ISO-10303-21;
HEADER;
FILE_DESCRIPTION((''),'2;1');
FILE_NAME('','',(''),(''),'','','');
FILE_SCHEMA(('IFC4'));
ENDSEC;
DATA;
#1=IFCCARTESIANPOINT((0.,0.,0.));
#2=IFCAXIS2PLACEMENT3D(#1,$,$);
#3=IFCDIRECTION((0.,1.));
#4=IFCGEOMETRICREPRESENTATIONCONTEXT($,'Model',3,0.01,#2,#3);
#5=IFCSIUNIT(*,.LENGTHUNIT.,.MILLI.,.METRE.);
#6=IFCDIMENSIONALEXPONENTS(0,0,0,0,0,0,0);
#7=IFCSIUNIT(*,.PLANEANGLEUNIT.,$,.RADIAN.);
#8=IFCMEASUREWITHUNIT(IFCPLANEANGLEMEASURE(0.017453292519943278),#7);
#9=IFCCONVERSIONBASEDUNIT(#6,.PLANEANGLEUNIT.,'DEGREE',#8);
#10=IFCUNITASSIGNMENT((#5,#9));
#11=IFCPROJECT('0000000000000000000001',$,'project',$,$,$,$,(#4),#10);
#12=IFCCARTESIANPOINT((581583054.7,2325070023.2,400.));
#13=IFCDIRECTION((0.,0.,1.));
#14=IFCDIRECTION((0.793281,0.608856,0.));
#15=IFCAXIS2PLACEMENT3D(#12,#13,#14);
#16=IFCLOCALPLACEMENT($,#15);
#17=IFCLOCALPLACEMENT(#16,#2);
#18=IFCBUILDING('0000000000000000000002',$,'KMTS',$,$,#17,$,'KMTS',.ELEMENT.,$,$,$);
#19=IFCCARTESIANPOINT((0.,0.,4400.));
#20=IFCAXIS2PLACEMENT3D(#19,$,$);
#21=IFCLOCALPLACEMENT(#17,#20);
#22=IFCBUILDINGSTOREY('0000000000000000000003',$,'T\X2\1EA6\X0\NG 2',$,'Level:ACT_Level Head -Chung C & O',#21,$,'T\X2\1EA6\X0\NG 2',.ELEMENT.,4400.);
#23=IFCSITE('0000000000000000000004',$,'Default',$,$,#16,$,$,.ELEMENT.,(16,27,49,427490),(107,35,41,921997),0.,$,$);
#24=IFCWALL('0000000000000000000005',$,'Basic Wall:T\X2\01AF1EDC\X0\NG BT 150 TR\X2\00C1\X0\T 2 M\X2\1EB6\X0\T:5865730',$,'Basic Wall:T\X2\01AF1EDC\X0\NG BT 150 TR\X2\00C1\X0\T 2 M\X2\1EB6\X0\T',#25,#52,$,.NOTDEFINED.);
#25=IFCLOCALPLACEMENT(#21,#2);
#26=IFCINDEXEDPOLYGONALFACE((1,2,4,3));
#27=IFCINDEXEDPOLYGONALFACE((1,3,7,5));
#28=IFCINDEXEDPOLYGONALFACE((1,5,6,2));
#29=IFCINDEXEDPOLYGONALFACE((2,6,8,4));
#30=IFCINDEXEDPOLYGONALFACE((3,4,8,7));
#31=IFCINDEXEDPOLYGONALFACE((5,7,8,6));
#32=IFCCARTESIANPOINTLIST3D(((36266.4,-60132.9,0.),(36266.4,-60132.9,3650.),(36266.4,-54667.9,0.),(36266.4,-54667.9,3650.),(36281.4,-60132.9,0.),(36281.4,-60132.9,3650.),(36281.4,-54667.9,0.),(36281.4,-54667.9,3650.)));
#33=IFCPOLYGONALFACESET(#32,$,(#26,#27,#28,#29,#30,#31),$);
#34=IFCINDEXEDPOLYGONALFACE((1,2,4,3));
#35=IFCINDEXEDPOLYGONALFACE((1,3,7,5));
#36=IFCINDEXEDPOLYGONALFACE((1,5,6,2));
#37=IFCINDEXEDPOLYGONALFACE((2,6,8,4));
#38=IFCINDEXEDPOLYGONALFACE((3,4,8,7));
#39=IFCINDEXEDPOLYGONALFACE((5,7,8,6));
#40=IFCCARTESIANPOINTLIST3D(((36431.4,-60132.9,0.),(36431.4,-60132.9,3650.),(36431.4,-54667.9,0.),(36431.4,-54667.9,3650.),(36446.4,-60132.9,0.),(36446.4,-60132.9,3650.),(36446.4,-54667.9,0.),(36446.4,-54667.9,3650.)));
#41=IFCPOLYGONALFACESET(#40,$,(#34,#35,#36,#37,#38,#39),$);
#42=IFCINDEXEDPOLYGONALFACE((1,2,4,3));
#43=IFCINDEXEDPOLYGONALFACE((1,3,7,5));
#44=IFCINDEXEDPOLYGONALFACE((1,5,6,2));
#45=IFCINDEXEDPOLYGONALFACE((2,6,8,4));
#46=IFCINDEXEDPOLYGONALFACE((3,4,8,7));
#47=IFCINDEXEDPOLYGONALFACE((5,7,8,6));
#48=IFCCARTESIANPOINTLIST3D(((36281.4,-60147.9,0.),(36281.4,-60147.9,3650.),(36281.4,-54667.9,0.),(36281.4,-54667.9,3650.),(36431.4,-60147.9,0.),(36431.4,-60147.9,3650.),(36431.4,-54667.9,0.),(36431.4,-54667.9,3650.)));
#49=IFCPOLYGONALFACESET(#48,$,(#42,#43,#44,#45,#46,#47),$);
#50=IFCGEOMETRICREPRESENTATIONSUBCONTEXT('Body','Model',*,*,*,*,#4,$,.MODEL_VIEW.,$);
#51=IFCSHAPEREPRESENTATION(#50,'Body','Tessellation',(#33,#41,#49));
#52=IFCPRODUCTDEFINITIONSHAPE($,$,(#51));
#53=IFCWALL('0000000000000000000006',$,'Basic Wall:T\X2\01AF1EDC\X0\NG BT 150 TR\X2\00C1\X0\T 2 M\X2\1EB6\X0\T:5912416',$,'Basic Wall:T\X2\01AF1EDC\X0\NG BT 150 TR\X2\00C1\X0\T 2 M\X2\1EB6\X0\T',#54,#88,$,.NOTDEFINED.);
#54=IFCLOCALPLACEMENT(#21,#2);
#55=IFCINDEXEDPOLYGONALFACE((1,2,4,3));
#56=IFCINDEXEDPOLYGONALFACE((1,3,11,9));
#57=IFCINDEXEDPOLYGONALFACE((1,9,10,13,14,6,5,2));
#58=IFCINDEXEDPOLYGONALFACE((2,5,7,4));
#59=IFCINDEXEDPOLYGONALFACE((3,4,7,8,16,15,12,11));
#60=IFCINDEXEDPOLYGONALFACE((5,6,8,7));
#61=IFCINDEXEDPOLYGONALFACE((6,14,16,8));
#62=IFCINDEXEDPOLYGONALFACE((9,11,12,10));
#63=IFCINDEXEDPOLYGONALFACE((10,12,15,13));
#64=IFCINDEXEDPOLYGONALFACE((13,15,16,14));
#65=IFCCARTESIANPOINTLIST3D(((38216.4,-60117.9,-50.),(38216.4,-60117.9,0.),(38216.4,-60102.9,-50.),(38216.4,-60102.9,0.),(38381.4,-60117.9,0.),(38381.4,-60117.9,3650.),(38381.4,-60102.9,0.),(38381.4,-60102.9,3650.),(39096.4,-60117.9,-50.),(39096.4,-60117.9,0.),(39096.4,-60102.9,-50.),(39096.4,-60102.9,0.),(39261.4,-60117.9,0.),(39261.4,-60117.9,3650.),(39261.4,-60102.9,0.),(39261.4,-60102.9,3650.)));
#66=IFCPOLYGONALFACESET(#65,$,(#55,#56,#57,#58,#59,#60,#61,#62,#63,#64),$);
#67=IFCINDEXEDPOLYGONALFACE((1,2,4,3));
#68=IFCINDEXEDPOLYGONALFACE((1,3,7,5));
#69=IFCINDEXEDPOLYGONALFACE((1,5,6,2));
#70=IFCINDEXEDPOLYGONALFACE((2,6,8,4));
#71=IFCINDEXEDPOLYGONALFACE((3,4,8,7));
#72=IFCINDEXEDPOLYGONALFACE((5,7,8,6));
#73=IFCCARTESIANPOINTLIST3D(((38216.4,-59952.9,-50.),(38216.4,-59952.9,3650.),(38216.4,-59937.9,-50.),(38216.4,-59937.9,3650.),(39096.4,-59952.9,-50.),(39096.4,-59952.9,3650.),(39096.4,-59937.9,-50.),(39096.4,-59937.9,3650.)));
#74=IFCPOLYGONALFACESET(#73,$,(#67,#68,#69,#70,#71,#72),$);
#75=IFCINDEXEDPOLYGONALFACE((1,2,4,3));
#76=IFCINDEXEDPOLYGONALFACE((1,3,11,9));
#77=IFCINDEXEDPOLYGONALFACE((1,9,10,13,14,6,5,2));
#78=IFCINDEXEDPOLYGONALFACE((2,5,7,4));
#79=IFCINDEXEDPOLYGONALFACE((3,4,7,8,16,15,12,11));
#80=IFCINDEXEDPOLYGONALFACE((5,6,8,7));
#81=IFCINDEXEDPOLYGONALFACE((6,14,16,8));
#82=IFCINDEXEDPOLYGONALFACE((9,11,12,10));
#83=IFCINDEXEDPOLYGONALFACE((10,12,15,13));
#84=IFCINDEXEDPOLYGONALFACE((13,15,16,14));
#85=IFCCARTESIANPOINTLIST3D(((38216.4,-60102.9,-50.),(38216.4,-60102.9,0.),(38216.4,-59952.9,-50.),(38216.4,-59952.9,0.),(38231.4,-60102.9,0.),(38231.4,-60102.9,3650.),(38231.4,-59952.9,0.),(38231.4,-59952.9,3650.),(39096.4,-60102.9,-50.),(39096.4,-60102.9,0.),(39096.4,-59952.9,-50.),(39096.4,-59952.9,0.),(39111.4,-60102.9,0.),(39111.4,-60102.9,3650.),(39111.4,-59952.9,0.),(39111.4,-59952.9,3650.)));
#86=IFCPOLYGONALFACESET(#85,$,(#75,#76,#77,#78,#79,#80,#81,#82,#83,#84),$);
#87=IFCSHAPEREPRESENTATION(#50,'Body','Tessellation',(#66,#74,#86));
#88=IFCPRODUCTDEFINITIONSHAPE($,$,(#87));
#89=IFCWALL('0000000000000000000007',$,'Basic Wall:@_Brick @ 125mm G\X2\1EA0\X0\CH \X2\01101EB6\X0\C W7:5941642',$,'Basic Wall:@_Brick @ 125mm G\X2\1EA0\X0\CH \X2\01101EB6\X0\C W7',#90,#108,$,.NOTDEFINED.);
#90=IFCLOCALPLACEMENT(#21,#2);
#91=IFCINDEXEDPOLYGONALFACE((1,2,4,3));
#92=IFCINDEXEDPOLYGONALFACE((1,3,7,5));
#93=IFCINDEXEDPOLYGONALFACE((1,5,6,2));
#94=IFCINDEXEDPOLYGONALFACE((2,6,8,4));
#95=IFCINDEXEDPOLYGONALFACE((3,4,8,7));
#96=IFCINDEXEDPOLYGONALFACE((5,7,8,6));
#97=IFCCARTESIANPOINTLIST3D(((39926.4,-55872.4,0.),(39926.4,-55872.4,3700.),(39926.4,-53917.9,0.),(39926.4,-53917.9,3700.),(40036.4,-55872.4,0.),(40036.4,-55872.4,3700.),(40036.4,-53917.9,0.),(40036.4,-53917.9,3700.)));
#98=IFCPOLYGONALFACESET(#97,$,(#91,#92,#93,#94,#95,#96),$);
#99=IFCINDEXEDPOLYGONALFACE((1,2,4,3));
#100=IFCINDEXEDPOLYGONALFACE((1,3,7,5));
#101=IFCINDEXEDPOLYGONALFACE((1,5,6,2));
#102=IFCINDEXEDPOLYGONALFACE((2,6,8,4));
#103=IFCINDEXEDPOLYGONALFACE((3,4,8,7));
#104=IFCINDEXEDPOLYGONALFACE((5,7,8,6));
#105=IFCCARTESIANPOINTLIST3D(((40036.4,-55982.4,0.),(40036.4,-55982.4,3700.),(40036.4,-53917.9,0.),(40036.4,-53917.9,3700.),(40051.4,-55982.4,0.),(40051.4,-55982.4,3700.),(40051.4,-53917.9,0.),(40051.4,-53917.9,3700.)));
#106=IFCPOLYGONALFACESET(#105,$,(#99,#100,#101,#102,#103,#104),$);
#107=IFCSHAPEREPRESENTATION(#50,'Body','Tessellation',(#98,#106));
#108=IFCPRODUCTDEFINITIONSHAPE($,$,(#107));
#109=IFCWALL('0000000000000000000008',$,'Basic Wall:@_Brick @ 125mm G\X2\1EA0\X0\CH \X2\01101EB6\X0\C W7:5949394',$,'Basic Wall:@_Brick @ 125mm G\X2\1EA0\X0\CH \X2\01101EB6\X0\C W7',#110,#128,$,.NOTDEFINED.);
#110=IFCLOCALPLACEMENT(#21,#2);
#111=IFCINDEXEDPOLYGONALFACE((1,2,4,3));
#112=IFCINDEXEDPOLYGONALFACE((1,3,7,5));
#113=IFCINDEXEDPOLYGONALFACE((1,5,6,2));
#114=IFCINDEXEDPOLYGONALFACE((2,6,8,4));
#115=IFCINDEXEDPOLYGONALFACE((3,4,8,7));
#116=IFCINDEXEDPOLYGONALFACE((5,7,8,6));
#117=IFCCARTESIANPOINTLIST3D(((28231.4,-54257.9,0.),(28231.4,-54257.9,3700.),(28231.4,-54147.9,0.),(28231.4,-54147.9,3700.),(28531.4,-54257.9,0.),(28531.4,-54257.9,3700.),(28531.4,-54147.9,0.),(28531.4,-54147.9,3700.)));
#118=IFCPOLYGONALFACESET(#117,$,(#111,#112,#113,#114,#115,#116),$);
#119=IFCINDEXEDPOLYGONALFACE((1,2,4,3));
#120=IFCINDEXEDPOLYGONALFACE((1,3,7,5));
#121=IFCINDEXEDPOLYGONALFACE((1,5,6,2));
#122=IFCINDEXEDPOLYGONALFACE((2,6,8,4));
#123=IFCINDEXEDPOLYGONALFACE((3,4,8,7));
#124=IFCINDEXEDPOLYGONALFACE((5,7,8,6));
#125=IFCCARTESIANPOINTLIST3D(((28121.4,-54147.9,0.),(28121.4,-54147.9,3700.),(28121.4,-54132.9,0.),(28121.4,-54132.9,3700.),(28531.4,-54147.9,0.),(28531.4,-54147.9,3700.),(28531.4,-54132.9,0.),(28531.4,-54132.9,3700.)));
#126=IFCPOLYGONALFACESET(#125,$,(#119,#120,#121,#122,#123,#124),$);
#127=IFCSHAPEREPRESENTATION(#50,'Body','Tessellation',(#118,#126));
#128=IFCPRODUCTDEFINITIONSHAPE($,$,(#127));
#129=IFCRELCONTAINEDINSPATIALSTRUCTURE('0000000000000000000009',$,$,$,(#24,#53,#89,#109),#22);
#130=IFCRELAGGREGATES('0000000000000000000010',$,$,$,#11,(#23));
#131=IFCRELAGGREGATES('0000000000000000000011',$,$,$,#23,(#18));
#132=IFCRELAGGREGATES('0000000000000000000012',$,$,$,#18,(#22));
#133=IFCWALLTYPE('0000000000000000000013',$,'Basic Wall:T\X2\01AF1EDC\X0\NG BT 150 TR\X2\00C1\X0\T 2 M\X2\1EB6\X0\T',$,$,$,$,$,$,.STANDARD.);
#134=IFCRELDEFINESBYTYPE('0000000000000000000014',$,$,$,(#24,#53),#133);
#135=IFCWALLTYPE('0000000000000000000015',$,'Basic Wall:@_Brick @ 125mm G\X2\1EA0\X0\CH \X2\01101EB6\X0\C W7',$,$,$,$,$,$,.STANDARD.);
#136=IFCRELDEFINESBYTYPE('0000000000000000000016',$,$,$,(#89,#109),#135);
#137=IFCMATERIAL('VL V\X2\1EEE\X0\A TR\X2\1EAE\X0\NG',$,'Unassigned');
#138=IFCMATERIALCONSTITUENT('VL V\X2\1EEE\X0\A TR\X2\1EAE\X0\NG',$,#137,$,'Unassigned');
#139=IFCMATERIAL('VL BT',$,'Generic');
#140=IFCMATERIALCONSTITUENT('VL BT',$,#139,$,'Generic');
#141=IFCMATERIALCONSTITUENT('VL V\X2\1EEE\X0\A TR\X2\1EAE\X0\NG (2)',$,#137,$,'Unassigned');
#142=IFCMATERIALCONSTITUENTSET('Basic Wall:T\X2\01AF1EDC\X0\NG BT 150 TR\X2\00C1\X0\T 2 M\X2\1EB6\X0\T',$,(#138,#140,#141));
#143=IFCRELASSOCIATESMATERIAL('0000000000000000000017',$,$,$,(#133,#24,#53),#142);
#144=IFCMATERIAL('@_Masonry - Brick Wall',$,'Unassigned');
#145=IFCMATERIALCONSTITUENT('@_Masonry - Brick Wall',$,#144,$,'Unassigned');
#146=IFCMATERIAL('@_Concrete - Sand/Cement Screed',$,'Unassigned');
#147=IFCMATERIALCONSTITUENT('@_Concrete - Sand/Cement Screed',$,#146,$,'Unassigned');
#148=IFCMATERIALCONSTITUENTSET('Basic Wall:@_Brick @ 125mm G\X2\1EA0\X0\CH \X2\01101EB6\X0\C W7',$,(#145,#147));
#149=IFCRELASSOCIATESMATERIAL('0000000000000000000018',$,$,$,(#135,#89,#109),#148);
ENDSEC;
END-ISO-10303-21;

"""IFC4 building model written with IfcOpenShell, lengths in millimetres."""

from ifc_helpers import new_model, entity, si_unit, converted_unit, direction, frame, origin, place, context, subcontext, project, spatial, indexed_curve, outline, extrude, material, constituent, constituent_set, type_object, element, save


model = new_model("IFC4")

# Units and contexts
model_context = context("Model", 3, precision=0.01, world=origin(), true_north=direction((0.0, 1.0)))
body_context = subcontext(model_context, "Body", "Model", "MODEL_VIEW")
ifc_project = project(units=[si_unit("LENGTHUNIT", "METRE", prefix="MILLI"), converted_unit("PLANEANGLEUNIT", "DEGREE", entity("IfcPlaneAngleMeasure", 0.017453292519943278), si_unit("PLANEANGLEUNIT", "RADIAN"), dimensions=[0, 0, 0, 0, 0, 0, 0])], contexts=[model_context])

# Site, building, storey
site_placement = place(None, frame((581583054.7, 2325070023.2, 400.0), z_axis=(0.0, 0.0, 1.0), x_axis=(0.793281, 0.608856, 0.0)))
site = spatial("IfcSite", under=ifc_project, at=site_placement, Name="Default", CompositionType="ELEMENT", RefLatitude=(16, 27, 49, 427490), RefLongitude=(107, 35, 41, 921997), RefElevation=0.0)
building_placement = place(site_placement, origin())
building = spatial("IfcBuilding", under=site, at=building_placement, Name="KMTS", LongName="KMTS", CompositionType="ELEMENT")
storey_placement = place(building_placement, frame((0.0, 0.0, 4400.0)))
storey = spatial("IfcBuildingStorey", under=building, at=storey_placement, Name="TẦNG 2", ObjectType="Level:ACT_Level Head -Chung C & O", LongName="TẦNG 2", CompositionType="ELEMENT", Elevation=4400.0)

# Wall
ifc_material_1 = material(Name="VL VỮA TRẮNG", Category="Unassigned")
ifc_constituent_1 = constituent(ifc_material_1, Name="VL VỮA TRẮNG", Category="Unassigned")
ifc_material_2 = material(Name="VL BT", Category="Generic")
ifc_constituent_2 = constituent(ifc_material_2, Name="VL BT", Category="Generic")
ifc_constituent_3 = constituent(ifc_material_1, Name="VL VỮA TRẮNG (2)", Category="Unassigned")
ifc_constituent_set_1 = constituent_set(constituents=[ifc_constituent_1, ifc_constituent_2, ifc_constituent_3], Name="Basic Wall:TƯỜNG BT 150 TRÁT 2 MẶT")
wall_type_1 = type_object("IfcWallType", Name="Basic Wall:TƯỜNG BT 150 TRÁT 2 MẶT", PredefinedType="STANDARD", material=ifc_constituent_set_1)
wall_1_placement = place(storey_placement, frame((36356.4, -54667.9, 0.0), z_axis=(0.0, 0.0, 1.0), x_axis=(0.0, -1.0, 0.0)))
element("IfcWall", 1, at=wall_1_placement, inside=storey, type_object=wall_type_1, material=ifc_constituent_set_1, Name="Basic Wall:TƯỜNG BT 150 TRÁT 2 MẶT:5865730", ObjectType="Basic Wall:TƯỜNG BT 150 TRÁT 2 MẶT", PredefinedType="NOTDEFINED", context=body_context, shape_type="SweptSolid", body=[
    extrude(outline(indexed_curve([(-7.5, -2732.5), (7.5, -2732.5), (7.5, 2732.5), (-7.5, 2732.5), (-7.5, -2732.5)], self_intersect=False)), frame((2732.5, -82.5, 0.0), z_axis=(0.0, 0.0, 1.0), x_axis=(0.0, 1.0, 0.0)), (0.0, 0.0, 1.0), 3650.0),
    extrude(outline(indexed_curve([(-7.5, -2732.5), (7.5, -2732.5), (7.5, 2732.5), (-7.5, 2732.5), (-7.5, -2732.5)], self_intersect=False)), frame((2732.5, 82.5, 0.0), z_axis=(0.0, 0.0, 1.0), x_axis=(0.0, -1.0, 0.0)), (0.0, 0.0, 1.0), 3650.0),
    extrude(outline(indexed_curve([(-2740.0, -75.0), (2740.0, -75.0), (2740.0, 75.0), (-2740.0, 75.0), (-2740.0, -75.0)], self_intersect=False)), frame((2740.0, 0.0, 0.0)), (0.0, 0.0, 1.0), 3650.0),
])

# Wall
wall_2_placement = place(storey_placement, frame((38216.4, -60027.9, -50.0)))
element("IfcWall", 2, at=wall_2_placement, inside=storey, type_object=wall_type_1, material=ifc_constituent_set_1, Name="Basic Wall:TƯỜNG BT 150 TRÁT 2 MẶT:5912416", ObjectType="Basic Wall:TƯỜNG BT 150 TRÁT 2 MẶT", PredefinedType="NOTDEFINED", context=body_context, shape_type="SweptSolid", body=[
    extrude(outline(indexed_curve([(-950.0, -522.5), (-900.0, -522.5), (-900.0, -357.5), (2750.0, -357.5), (2750.0, 522.5), (-900.0, 522.5), (-900.0, 357.5), (-950.0, 357.5), (-950.0, -522.5)], self_intersect=False)), frame((522.5, -90.0, 950.0), z_axis=(0.0, 1.0, 0.0), x_axis=(0.0, 0.0, 1.0)), (0.0, 0.0, 1.0), 15.0),
    extrude(outline(indexed_curve([(-7.5, -440.0), (7.5, -440.0), (7.5, 440.0), (-7.5, 440.0), (-7.5, -440.0)], self_intersect=False)), frame((440.0, 82.5, 0.0), z_axis=(0.0, 0.0, 1.0), x_axis=(0.0, -1.0, 0.0)), (0.0, 0.0, 1.0), 3700.0),
    extrude(outline(indexed_curve([(-950.0, -447.5), (-900.0, -447.5), (-900.0, -432.5), (2750.0, -432.5), (2750.0, 447.5), (-900.0, 447.5), (-900.0, 432.5), (-950.0, 432.5), (-950.0, -447.5)], self_intersect=False)), frame((447.5, -75.0, 950.0), z_axis=(0.0, 1.0, 0.0), x_axis=(0.0, 0.0, 1.0)), (0.0, 0.0, 1.0), 150.0),
])

# Walls
ifc_material_3 = material(Name="@_Masonry - Brick Wall", Category="Unassigned")
ifc_constituent_4 = constituent(ifc_material_3, Name="@_Masonry - Brick Wall", Category="Unassigned")
ifc_material_4 = material(Name="@_Concrete - Sand/Cement Screed", Category="Unassigned")
ifc_constituent_5 = constituent(ifc_material_4, Name="@_Concrete - Sand/Cement Screed", Category="Unassigned")
ifc_constituent_set_2 = constituent_set(constituents=[ifc_constituent_4, ifc_constituent_5], Name="Basic Wall:@_Brick @ 125mm GẠCH ĐẶC W7")
wall_type_2 = type_object("IfcWallType", Name="Basic Wall:@_Brick @ 125mm GẠCH ĐẶC W7", PredefinedType="STANDARD", material=ifc_constituent_set_2)
wall_3_placement = place(storey_placement, frame((39988.9, -55872.4, 0.0), z_axis=(0.0, 0.0, 1.0), x_axis=(0.0, 1.0, 0.0)))
element("IfcWall", 3, at=wall_3_placement, inside=storey, type_object=wall_type_2, material=ifc_constituent_set_2, Name="Basic Wall:@_Brick @ 125mm GẠCH ĐẶC W7:5941642", ObjectType="Basic Wall:@_Brick @ 125mm GẠCH ĐẶC W7", PredefinedType="NOTDEFINED", context=body_context, shape_type="SweptSolid", body=[
    extrude(outline(indexed_curve([(-55.0, -977.2), (55.0, -977.2), (55.0, 977.2), (-55.0, 977.2), (-55.0, -977.2)], self_intersect=False)), frame((977.2, 7.5, 0.0), z_axis=(0.0, 0.0, 1.0), x_axis=(0.0, -1.0, 0.0)), (0.0, 0.0, 1.0), 3700.0),
    extrude(outline(indexed_curve([(-7.5, -1032.2), (7.5, -1032.2), (7.5, 1032.2), (-7.5, 1032.2), (-7.5, -1032.2)], self_intersect=False)), frame((922.2, -55.0, 0.0), z_axis=(0.0, 0.0, 1.0), x_axis=(0.0, 1.0, 0.0)), (0.0, 0.0, 1.0), 3700.0),
])
wall_4_placement = place(storey_placement, frame((28531.4, -54195.4, 0.0), z_axis=(0.0, 0.0, 1.0), x_axis=(-1.0, 0.0, 0.0)))
element("IfcWall", 4, at=wall_4_placement, inside=storey, type_object=wall_type_2, material=ifc_constituent_set_2, Name="Basic Wall:@_Brick @ 125mm GẠCH ĐẶC W7:5949394", ObjectType="Basic Wall:@_Brick @ 125mm GẠCH ĐẶC W7", PredefinedType="NOTDEFINED", context=body_context, shape_type="SweptSolid", body=[
    extrude(outline(indexed_curve([(-55.0, -150.0), (55.0, -150.0), (55.0, 150.0), (-55.0, 150.0), (-55.0, -150.0)], self_intersect=False)), frame((150.0, 7.5, 0.0), z_axis=(0.0, 0.0, 1.0), x_axis=(0.0, -1.0, 0.0)), (0.0, 0.0, 1.0), 3700.0),
    extrude(outline(indexed_curve([(-7.5, -205.0), (7.5, -205.0), (7.5, 205.0), (-7.5, 205.0), (-7.5, -205.0)], self_intersect=False)), frame((205.0, -55.0, 0.0), z_axis=(0.0, 0.0, 1.0), x_axis=(0.0, 1.0, 0.0)), (0.0, 0.0, 1.0), 3700.0),
])

save(model, "model.ifc")
